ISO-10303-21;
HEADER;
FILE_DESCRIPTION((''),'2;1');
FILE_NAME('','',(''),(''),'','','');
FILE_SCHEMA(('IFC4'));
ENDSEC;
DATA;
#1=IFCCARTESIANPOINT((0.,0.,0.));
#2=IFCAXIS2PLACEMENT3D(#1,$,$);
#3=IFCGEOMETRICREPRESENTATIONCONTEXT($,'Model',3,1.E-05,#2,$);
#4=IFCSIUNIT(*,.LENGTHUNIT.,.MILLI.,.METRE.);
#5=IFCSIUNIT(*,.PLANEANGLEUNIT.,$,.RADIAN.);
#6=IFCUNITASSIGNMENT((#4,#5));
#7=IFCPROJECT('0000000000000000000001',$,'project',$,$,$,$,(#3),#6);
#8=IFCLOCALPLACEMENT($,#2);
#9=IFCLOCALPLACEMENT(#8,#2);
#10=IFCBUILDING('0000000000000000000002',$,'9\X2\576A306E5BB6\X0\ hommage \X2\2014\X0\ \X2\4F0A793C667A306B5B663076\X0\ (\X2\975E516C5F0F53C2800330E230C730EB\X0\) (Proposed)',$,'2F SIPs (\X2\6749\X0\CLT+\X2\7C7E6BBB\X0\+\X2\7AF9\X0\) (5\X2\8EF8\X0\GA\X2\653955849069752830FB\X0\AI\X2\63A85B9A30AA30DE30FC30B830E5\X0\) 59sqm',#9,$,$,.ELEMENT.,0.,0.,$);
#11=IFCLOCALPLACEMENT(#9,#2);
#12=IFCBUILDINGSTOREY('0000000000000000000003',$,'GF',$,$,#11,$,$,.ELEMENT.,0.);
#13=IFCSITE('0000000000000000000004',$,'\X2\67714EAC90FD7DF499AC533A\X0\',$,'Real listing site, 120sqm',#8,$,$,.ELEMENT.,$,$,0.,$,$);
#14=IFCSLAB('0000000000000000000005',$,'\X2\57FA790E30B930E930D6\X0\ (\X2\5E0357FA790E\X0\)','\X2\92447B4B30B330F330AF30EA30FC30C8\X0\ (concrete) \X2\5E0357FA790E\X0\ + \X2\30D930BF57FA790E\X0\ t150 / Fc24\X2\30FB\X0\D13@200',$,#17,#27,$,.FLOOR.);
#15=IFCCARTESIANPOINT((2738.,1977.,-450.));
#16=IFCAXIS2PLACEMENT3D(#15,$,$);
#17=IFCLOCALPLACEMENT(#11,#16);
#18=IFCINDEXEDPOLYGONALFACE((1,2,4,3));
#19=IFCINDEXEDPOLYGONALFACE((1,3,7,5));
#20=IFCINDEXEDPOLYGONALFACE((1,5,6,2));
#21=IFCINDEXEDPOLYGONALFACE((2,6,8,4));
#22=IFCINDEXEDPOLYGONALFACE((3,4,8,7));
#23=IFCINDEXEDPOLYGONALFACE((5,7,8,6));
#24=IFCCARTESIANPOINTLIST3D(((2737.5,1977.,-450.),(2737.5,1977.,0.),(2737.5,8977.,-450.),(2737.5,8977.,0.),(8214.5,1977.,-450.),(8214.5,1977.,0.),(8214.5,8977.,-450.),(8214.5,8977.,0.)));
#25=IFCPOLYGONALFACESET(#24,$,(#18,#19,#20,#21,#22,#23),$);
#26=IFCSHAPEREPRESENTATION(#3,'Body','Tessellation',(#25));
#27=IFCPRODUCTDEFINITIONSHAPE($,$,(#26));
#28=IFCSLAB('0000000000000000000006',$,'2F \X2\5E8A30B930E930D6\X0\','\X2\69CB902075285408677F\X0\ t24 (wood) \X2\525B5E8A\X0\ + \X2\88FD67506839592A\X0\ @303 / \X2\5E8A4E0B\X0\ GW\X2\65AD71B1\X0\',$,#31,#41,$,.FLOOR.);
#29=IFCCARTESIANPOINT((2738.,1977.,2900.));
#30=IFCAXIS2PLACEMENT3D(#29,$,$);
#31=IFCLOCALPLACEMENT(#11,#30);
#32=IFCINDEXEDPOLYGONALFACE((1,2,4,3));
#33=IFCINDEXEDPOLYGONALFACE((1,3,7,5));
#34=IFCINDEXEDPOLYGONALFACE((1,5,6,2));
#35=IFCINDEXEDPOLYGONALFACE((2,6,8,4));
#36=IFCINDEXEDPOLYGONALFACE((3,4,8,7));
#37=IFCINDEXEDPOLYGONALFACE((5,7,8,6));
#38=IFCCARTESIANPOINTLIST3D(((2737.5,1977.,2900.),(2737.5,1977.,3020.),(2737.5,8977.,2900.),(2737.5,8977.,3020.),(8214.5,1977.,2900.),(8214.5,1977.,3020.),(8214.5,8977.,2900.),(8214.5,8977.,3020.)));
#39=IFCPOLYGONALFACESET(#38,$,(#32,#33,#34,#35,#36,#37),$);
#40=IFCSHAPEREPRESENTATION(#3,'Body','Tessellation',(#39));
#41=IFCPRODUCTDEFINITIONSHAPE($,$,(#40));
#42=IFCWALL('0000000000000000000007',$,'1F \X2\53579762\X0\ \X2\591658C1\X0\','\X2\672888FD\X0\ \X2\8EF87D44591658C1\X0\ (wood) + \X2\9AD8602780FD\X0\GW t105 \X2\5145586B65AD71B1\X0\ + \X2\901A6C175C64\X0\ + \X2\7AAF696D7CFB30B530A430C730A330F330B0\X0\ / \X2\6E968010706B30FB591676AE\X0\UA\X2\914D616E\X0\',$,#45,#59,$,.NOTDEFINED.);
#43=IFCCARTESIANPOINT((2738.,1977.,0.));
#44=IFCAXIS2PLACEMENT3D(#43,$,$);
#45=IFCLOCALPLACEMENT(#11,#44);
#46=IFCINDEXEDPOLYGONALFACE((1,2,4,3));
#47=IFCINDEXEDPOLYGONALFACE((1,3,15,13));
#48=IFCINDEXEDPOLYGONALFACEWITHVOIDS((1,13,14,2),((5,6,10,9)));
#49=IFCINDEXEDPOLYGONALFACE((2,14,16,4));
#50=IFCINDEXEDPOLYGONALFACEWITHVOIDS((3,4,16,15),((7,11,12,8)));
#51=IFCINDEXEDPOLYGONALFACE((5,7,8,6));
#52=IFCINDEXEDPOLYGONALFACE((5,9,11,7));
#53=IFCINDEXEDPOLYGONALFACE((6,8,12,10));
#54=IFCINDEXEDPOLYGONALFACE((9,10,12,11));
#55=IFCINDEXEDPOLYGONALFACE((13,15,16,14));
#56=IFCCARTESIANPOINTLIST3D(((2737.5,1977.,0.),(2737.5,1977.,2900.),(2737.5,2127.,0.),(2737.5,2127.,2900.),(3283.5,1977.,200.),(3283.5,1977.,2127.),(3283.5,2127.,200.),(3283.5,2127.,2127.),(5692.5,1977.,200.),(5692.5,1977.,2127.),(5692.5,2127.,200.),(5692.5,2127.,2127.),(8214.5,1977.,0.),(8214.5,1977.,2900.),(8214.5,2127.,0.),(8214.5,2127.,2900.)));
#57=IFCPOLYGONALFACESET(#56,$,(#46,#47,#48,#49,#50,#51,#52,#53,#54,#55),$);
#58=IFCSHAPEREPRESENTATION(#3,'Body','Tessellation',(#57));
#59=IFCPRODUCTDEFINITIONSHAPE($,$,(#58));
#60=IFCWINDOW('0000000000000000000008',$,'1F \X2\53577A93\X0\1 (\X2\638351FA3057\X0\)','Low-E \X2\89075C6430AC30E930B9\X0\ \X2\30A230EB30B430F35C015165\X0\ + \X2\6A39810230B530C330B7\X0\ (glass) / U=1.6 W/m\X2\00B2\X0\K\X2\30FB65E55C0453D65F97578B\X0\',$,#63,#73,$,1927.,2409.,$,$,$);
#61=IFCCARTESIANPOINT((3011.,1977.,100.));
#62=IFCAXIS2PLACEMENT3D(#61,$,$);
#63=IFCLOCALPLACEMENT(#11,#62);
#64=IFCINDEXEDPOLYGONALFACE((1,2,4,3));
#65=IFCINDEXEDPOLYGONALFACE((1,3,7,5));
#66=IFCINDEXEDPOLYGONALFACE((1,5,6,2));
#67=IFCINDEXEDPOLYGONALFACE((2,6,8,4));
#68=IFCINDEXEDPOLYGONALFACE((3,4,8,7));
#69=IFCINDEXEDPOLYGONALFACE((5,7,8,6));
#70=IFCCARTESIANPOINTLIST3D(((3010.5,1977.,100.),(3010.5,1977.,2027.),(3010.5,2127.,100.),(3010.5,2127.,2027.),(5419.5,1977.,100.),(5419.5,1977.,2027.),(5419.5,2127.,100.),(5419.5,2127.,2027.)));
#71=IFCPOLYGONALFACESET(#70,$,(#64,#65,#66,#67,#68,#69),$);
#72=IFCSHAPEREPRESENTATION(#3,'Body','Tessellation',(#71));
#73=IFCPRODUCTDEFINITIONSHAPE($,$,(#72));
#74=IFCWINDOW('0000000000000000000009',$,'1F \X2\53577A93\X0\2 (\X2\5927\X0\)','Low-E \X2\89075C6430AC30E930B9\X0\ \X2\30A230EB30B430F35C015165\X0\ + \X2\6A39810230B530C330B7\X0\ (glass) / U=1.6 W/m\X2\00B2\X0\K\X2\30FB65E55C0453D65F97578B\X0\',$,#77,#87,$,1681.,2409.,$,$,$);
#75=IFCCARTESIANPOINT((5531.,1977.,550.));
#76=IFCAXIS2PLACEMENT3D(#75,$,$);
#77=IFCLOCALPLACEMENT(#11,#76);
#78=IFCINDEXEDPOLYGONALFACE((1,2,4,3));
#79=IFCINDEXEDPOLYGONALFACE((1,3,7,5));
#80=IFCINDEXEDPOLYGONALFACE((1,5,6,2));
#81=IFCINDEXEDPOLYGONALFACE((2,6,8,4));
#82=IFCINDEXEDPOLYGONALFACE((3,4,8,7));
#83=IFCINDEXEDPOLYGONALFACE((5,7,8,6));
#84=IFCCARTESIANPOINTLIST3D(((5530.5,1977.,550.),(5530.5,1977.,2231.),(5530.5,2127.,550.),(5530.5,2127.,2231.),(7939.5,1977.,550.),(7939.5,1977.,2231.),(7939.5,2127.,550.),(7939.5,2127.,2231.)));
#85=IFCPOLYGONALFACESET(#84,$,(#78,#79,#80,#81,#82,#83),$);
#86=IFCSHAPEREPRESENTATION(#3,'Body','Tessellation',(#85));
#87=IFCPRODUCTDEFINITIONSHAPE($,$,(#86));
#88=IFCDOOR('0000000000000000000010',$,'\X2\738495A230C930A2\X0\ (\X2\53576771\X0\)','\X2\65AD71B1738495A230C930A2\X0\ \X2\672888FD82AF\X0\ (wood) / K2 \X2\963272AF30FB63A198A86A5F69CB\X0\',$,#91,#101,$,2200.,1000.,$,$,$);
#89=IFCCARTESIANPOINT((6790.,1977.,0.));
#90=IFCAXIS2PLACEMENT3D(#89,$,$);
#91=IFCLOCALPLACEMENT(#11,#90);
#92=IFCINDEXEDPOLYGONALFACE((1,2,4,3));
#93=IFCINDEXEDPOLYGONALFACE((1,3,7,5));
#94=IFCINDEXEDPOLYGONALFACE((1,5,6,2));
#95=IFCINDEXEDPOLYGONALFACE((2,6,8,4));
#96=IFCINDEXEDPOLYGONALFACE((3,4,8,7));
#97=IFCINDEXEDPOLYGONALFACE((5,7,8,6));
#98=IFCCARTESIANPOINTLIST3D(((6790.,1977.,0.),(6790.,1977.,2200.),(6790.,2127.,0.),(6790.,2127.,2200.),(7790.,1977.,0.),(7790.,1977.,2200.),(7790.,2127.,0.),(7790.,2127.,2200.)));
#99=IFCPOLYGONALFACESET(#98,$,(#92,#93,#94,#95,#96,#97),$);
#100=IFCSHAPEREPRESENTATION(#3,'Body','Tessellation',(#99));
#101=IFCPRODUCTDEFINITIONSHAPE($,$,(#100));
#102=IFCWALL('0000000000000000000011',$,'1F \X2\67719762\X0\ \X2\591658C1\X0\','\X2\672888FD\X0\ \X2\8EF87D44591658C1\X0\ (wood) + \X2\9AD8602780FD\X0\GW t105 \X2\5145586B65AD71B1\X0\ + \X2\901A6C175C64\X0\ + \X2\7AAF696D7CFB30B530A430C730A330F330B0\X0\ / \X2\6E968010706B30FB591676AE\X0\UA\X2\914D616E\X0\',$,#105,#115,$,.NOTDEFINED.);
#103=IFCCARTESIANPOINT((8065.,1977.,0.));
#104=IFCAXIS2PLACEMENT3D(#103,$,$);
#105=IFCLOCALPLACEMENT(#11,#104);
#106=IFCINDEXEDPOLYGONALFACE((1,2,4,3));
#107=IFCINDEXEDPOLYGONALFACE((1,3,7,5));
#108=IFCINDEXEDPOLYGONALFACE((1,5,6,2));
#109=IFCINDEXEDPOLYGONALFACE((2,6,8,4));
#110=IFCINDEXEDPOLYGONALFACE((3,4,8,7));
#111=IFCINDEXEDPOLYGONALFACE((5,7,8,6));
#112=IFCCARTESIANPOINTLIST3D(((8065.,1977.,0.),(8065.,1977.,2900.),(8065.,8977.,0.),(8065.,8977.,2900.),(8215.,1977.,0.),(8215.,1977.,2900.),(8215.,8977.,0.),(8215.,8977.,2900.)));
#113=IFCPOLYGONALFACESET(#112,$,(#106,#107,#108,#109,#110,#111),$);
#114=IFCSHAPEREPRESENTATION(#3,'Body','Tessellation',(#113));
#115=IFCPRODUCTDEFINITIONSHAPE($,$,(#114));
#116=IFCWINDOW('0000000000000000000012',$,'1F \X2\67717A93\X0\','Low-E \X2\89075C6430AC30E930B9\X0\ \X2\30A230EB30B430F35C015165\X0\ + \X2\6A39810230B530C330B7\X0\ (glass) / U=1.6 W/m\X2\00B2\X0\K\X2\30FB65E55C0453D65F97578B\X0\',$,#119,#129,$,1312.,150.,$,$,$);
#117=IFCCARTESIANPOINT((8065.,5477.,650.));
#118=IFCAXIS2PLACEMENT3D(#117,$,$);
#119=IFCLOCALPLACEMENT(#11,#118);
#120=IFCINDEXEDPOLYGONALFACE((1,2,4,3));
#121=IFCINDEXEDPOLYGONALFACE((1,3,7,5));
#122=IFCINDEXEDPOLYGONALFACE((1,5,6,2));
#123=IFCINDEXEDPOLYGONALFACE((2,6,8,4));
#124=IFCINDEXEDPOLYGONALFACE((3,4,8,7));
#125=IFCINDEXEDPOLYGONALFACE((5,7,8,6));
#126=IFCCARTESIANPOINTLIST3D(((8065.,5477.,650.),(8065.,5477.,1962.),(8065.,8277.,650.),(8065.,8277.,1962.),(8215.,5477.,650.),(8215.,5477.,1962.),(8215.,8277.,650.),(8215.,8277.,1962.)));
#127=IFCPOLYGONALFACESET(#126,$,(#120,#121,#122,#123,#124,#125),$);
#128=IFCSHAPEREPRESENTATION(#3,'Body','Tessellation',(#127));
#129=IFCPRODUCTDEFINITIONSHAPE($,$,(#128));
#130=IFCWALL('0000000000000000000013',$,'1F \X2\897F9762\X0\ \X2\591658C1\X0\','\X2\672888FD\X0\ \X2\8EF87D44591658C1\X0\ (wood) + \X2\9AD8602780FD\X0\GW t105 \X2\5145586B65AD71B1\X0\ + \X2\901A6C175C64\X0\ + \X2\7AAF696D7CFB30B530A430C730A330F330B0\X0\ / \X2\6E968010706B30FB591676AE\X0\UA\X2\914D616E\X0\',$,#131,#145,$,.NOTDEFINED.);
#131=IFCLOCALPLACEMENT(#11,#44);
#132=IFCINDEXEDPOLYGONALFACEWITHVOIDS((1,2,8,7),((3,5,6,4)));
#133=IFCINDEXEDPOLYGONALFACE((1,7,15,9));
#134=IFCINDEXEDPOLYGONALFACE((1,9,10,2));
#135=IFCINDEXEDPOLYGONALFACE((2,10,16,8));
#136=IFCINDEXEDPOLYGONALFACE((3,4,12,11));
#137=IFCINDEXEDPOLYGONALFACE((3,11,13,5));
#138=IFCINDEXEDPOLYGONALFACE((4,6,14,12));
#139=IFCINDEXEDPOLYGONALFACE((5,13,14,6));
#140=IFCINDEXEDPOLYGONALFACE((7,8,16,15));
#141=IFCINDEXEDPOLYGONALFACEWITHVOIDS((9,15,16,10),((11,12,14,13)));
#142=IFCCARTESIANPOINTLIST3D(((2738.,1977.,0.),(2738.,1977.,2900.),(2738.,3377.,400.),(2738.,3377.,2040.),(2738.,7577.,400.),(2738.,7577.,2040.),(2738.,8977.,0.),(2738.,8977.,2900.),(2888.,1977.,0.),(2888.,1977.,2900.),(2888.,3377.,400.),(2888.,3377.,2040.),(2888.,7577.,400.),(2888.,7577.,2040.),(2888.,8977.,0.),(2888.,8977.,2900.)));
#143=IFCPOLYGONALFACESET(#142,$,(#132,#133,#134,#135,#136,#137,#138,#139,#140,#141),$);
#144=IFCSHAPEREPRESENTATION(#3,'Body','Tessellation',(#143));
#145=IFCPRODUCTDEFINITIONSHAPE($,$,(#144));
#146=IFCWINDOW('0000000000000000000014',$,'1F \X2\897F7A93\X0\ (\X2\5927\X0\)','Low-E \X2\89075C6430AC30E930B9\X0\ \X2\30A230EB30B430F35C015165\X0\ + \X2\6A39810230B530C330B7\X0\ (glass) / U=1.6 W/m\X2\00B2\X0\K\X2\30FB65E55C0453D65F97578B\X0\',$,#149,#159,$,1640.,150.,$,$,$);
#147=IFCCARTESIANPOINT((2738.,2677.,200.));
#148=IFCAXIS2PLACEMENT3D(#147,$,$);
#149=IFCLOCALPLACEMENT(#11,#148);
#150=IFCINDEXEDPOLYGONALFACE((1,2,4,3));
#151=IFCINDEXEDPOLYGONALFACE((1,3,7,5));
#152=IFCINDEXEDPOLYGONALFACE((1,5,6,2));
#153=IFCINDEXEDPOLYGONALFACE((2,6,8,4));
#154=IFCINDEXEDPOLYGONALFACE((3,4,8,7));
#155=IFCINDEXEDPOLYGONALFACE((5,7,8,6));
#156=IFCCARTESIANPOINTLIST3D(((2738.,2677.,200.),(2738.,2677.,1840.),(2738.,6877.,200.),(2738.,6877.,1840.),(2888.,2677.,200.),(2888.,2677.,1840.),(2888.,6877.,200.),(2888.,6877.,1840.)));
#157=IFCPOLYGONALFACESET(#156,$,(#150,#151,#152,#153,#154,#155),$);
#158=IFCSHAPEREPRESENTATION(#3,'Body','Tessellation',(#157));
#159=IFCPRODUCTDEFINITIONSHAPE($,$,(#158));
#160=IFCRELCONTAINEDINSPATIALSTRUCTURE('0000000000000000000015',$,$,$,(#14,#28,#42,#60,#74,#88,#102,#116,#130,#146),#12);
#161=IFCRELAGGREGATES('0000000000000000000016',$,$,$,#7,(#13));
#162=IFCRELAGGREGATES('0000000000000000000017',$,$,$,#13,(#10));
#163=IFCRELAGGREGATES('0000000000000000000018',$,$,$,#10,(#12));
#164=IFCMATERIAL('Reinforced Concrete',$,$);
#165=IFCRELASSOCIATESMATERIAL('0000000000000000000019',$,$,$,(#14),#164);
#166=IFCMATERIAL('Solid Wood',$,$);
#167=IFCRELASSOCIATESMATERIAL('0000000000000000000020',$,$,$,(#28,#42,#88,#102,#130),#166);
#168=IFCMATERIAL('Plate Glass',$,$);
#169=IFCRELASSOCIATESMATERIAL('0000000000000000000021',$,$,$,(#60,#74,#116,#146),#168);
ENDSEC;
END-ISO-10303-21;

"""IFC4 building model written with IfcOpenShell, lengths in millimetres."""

from ifc_helpers import new_model, si_unit, frame, frame_2d, origin, place, context, project, spatial, rectangle, extrude, material, element, fill, save


model = new_model("IFC4")

# Units and contexts
model_context = context("Model", 3, precision=1e-05, world=origin())
ifc_project = project(units=[si_unit("LENGTHUNIT", "METRE", prefix="MILLI"), si_unit("PLANEANGLEUNIT", "RADIAN")], contexts=[model_context])

# Site, building, storey
site_placement = place(None, origin())
site = spatial("IfcSite", under=ifc_project, at=site_placement, Name="東京都練馬区", ObjectType="Real listing site, 120sqm", CompositionType="ELEMENT", RefElevation=0.0)
building_placement = place(site_placement, origin())
building = spatial("IfcBuilding", under=site, at=building_placement, Name="9坪の家 hommage — 伊礼智に学ぶ (非公式参考モデル) (Proposed)", ObjectType="2F SIPs (杉CLT+籾殻+竹) (5軸GA改善適用・AI推定オマージュ) 59sqm", CompositionType="ELEMENT", ElevationOfRefHeight=0.0, ElevationOfTerrain=0.0)
storey_placement = place(building_placement, origin())
storey = spatial("IfcBuildingStorey", under=building, at=storey_placement, Name="GF", CompositionType="ELEMENT", Elevation=0.0)

# Slabs
ifc_material_1 = material(Name="Reinforced Concrete")
slab_1_placement = place(storey_placement, frame((2738.0, 1977.0, -450.0)))
element("IfcSlab", 1, at=slab_1_placement, inside=storey, material=ifc_material_1, Name="基礎スラブ (布基礎)", Description="鉄筋コンクリート (concrete) 布基礎 + ベタ基礎 t150 / Fc24・D13@200", PredefinedType="FLOOR", context=model_context, shape_type="SweptSolid", body=[
    extrude(rectangle(XDim=5477.0, YDim=7000.0, at=frame_2d((2738.0, 3500.0))), frame((2738.0, 1977.0, -450.0)), (0.0, 0.0, 1.0), 450.0),
])
ifc_material_2 = material(Name="Solid Wood")
slab_2_placement = place(storey_placement, frame((2738.0, 1977.0, 2900.0)))
element("IfcSlab", 2, at=slab_2_placement, inside=storey, material=ifc_material_2, Name="2F 床スラブ", Description="構造用合板 t24 (wood) 剛床 + 製材根太 @303 / 床下 GW断熱", PredefinedType="FLOOR", context=model_context, shape_type="SweptSolid", body=[
    extrude(rectangle(XDim=5477.0, YDim=7000.0, at=frame_2d((2738.0, 3500.0))), frame((2738.0, 1977.0, 2900.0)), (0.0, 0.0, 1.0), 120.0),
])

# Wall, openings, windows, door
wall_1_placement = place(storey_placement, frame((2738.0, 1977.0, 0.0)))
wall_1 = element("IfcWall", 3, at=wall_1_placement, inside=storey, material=ifc_material_2, Name="1F 南面 外壁", Description="木製 軸組外壁 (wood) + 高性能GW t105 充填断熱 + 通気層 + 窯業系サイディング / 準耐火・外皮UA配慮", PredefinedType="NOTDEFINED", context=model_context, shape_type="SweptSolid", body=[
    extrude(rectangle(XDim=5477.0, YDim=150.0, at=frame_2d((2738.0, 75.0))), frame((2738.0, 1977.0, 0.0)), (0.0, 0.0, 1.0), 2900.0),
])
opening_1_placement = place(storey_placement, frame((3011.0, 1977.0, 100.0)))
opening_1 = element("IfcOpeningElement", 4, at=opening_1_placement, cuts=wall_1, PredefinedType="NOTDEFINED", context=model_context, shape_type="SweptSolid", body=[
    extrude(rectangle(XDim=2409.0, YDim=150.0, at=frame_2d((1204.0, 75.0))), frame((3011.0, 1977.0, 100.0)), (0.0, 0.0, 1.0), 1927.0),
])
opening_2_placement = place(storey_placement, frame((5531.0, 1977.0, 550.0)))
opening_2 = element("IfcOpeningElement", 5, at=opening_2_placement, cuts=wall_1, PredefinedType="NOTDEFINED", context=model_context, shape_type="SweptSolid", body=[
    extrude(rectangle(XDim=2409.0, YDim=150.0, at=frame_2d((1204.0, 75.0))), frame((5531.0, 1977.0, 550.0)), (0.0, 0.0, 1.0), 1681.0),
])
opening_3_placement = place(storey_placement, frame((6790.0, 1977.0, 0.0)))
opening_3 = element("IfcOpeningElement", 6, at=opening_3_placement, cuts=wall_1, PredefinedType="NOTDEFINED", context=model_context, shape_type="SweptSolid", body=[
    extrude(rectangle(XDim=1000.0, YDim=150.0, at=frame_2d((500.0, 75.0))), frame((6790.0, 1977.0, 0.0)), (0.0, 0.0, 1.0), 2200.0),
])
ifc_material_3 = material(Name="Plate Glass")
window_1_placement = place(storey_placement, frame((3011.0, 1977.0, 100.0)))
window_1 = element("IfcWindow", 7, at=window_1_placement, inside=storey, material=ifc_material_3, Name="1F 南窓1 (掃出し)", Description="Low-E 複層ガラス アルゴン封入 + 樹脂サッシ (glass) / U=1.6 W/m²K・日射取得型", OverallHeight=1927.0, OverallWidth=2409.0, context=model_context, shape_type="SweptSolid", body=[
    extrude(rectangle(XDim=2409.0, YDim=150.0, at=frame_2d((1204.0, 75.0))), frame((3011.0, 1977.0, 100.0)), (0.0, 0.0, 1.0), 1927.0),
])
fill(opening_1, window_1)
window_2_placement = place(storey_placement, frame((5531.0, 1977.0, 550.0)))
window_2 = element("IfcWindow", 8, at=window_2_placement, inside=storey, material=ifc_material_3, Name="1F 南窓2 (大)", Description="Low-E 複層ガラス アルゴン封入 + 樹脂サッシ (glass) / U=1.6 W/m²K・日射取得型", OverallHeight=1681.0, OverallWidth=2409.0, context=model_context, shape_type="SweptSolid", body=[
    extrude(rectangle(XDim=2409.0, YDim=150.0, at=frame_2d((1204.0, 75.0))), frame((5531.0, 1977.0, 550.0)), (0.0, 0.0, 1.0), 1681.0),
])
fill(opening_2, window_2)
door_placement = place(storey_placement, frame((6790.0, 1977.0, 0.0)))
door = element("IfcDoor", 9, at=door_placement, inside=storey, material=ifc_material_2, Name="玄関ドア (南東)", Description="断熱玄関ドア 木製芯 (wood) / K2 防犯・採風機構", OverallHeight=2200.0, OverallWidth=1000.0, context=model_context, shape_type="SweptSolid", body=[
    extrude(rectangle(XDim=1000.0, YDim=150.0, at=frame_2d((500.0, 75.0))), frame((6790.0, 1977.0, 0.0)), (0.0, 0.0, 1.0), 2200.0),
])
fill(opening_3, door)

# Walls, openings, windows
wall_2_placement = place(storey_placement, frame((8065.0, 1977.0, 0.0)))
wall_2 = element("IfcWall", 10, at=wall_2_placement, inside=storey, material=ifc_material_2, Name="1F 東面 外壁", Description="木製 軸組外壁 (wood) + 高性能GW t105 充填断熱 + 通気層 + 窯業系サイディング / 準耐火・外皮UA配慮", PredefinedType="NOTDEFINED", context=model_context, shape_type="SweptSolid", body=[
    extrude(rectangle(XDim=150.0, YDim=7000.0, at=frame_2d((75.0, 3500.0))), frame((8065.0, 1977.0, 0.0)), (0.0, 0.0, 1.0), 2900.0),
])
opening_4_placement = place(storey_placement, frame((8065.0, 5477.0, 650.0)))
opening_4 = element("IfcOpeningElement", 11, at=opening_4_placement, cuts=wall_2, PredefinedType="NOTDEFINED", context=model_context, shape_type="SweptSolid", body=[
    extrude(rectangle(XDim=150.0, YDim=2800.0, at=frame_2d((75.0, 1400.0))), frame((8065.0, 5477.0, 650.0)), (0.0, 0.0, 1.0), 1312.0),
])
window_3_placement = place(storey_placement, frame((8065.0, 5477.0, 650.0)))
window_3 = element("IfcWindow", 12, at=window_3_placement, inside=storey, material=ifc_material_3, Name="1F 東窓", Description="Low-E 複層ガラス アルゴン封入 + 樹脂サッシ (glass) / U=1.6 W/m²K・日射取得型", OverallHeight=1312.0, OverallWidth=150.0, context=model_context, shape_type="SweptSolid", body=[
    extrude(rectangle(XDim=150.0, YDim=2800.0, at=frame_2d((75.0, 1400.0))), frame((8065.0, 5477.0, 650.0)), (0.0, 0.0, 1.0), 1312.0),
])
fill(opening_4, window_3)
wall_3_placement = place(storey_placement, frame((2738.0, 1977.0, 0.0)))
wall_3 = element("IfcWall", 13, at=wall_3_placement, inside=storey, material=ifc_material_2, Name="1F 西面 外壁", Description="木製 軸組外壁 (wood) + 高性能GW t105 充填断熱 + 通気層 + 窯業系サイディング / 準耐火・外皮UA配慮", PredefinedType="NOTDEFINED", context=model_context, shape_type="SweptSolid", body=[
    extrude(rectangle(XDim=150.0, YDim=7000.0, at=frame_2d((75.0, 3500.0))), frame((2738.0, 1977.0, 0.0)), (0.0, 0.0, 1.0), 2900.0),
])
opening_5_placement = place(storey_placement, frame((2738.0, 2677.0, 200.0)))
opening_5 = element("IfcOpeningElement", 14, at=opening_5_placement, cuts=wall_3, PredefinedType="NOTDEFINED", context=model_context, shape_type="SweptSolid", body=[
    extrude(rectangle(XDim=150.0, YDim=4200.0, at=frame_2d((75.0, 2100.0))), frame((2738.0, 2677.0, 200.0)), (0.0, 0.0, 1.0), 1640.0),
])
window_4_placement = place(storey_placement, frame((2738.0, 2677.0, 200.0)))
window_4 = element("IfcWindow", 15, at=window_4_placement, inside=storey, material=ifc_material_3, Name="1F 西窓 (大)", Description="Low-E 複層ガラス アルゴン封入 + 樹脂サッシ (glass) / U=1.6 W/m²K・日射取得型", OverallHeight=1640.0, OverallWidth=150.0, context=model_context, shape_type="SweptSolid", body=[
    extrude(rectangle(XDim=150.0, YDim=4200.0, at=frame_2d((75.0, 2100.0))), frame((2738.0, 2677.0, 200.0)), (0.0, 0.0, 1.0), 1640.0),
])
fill(opening_5, window_4)

save(model, "model.ifc")
